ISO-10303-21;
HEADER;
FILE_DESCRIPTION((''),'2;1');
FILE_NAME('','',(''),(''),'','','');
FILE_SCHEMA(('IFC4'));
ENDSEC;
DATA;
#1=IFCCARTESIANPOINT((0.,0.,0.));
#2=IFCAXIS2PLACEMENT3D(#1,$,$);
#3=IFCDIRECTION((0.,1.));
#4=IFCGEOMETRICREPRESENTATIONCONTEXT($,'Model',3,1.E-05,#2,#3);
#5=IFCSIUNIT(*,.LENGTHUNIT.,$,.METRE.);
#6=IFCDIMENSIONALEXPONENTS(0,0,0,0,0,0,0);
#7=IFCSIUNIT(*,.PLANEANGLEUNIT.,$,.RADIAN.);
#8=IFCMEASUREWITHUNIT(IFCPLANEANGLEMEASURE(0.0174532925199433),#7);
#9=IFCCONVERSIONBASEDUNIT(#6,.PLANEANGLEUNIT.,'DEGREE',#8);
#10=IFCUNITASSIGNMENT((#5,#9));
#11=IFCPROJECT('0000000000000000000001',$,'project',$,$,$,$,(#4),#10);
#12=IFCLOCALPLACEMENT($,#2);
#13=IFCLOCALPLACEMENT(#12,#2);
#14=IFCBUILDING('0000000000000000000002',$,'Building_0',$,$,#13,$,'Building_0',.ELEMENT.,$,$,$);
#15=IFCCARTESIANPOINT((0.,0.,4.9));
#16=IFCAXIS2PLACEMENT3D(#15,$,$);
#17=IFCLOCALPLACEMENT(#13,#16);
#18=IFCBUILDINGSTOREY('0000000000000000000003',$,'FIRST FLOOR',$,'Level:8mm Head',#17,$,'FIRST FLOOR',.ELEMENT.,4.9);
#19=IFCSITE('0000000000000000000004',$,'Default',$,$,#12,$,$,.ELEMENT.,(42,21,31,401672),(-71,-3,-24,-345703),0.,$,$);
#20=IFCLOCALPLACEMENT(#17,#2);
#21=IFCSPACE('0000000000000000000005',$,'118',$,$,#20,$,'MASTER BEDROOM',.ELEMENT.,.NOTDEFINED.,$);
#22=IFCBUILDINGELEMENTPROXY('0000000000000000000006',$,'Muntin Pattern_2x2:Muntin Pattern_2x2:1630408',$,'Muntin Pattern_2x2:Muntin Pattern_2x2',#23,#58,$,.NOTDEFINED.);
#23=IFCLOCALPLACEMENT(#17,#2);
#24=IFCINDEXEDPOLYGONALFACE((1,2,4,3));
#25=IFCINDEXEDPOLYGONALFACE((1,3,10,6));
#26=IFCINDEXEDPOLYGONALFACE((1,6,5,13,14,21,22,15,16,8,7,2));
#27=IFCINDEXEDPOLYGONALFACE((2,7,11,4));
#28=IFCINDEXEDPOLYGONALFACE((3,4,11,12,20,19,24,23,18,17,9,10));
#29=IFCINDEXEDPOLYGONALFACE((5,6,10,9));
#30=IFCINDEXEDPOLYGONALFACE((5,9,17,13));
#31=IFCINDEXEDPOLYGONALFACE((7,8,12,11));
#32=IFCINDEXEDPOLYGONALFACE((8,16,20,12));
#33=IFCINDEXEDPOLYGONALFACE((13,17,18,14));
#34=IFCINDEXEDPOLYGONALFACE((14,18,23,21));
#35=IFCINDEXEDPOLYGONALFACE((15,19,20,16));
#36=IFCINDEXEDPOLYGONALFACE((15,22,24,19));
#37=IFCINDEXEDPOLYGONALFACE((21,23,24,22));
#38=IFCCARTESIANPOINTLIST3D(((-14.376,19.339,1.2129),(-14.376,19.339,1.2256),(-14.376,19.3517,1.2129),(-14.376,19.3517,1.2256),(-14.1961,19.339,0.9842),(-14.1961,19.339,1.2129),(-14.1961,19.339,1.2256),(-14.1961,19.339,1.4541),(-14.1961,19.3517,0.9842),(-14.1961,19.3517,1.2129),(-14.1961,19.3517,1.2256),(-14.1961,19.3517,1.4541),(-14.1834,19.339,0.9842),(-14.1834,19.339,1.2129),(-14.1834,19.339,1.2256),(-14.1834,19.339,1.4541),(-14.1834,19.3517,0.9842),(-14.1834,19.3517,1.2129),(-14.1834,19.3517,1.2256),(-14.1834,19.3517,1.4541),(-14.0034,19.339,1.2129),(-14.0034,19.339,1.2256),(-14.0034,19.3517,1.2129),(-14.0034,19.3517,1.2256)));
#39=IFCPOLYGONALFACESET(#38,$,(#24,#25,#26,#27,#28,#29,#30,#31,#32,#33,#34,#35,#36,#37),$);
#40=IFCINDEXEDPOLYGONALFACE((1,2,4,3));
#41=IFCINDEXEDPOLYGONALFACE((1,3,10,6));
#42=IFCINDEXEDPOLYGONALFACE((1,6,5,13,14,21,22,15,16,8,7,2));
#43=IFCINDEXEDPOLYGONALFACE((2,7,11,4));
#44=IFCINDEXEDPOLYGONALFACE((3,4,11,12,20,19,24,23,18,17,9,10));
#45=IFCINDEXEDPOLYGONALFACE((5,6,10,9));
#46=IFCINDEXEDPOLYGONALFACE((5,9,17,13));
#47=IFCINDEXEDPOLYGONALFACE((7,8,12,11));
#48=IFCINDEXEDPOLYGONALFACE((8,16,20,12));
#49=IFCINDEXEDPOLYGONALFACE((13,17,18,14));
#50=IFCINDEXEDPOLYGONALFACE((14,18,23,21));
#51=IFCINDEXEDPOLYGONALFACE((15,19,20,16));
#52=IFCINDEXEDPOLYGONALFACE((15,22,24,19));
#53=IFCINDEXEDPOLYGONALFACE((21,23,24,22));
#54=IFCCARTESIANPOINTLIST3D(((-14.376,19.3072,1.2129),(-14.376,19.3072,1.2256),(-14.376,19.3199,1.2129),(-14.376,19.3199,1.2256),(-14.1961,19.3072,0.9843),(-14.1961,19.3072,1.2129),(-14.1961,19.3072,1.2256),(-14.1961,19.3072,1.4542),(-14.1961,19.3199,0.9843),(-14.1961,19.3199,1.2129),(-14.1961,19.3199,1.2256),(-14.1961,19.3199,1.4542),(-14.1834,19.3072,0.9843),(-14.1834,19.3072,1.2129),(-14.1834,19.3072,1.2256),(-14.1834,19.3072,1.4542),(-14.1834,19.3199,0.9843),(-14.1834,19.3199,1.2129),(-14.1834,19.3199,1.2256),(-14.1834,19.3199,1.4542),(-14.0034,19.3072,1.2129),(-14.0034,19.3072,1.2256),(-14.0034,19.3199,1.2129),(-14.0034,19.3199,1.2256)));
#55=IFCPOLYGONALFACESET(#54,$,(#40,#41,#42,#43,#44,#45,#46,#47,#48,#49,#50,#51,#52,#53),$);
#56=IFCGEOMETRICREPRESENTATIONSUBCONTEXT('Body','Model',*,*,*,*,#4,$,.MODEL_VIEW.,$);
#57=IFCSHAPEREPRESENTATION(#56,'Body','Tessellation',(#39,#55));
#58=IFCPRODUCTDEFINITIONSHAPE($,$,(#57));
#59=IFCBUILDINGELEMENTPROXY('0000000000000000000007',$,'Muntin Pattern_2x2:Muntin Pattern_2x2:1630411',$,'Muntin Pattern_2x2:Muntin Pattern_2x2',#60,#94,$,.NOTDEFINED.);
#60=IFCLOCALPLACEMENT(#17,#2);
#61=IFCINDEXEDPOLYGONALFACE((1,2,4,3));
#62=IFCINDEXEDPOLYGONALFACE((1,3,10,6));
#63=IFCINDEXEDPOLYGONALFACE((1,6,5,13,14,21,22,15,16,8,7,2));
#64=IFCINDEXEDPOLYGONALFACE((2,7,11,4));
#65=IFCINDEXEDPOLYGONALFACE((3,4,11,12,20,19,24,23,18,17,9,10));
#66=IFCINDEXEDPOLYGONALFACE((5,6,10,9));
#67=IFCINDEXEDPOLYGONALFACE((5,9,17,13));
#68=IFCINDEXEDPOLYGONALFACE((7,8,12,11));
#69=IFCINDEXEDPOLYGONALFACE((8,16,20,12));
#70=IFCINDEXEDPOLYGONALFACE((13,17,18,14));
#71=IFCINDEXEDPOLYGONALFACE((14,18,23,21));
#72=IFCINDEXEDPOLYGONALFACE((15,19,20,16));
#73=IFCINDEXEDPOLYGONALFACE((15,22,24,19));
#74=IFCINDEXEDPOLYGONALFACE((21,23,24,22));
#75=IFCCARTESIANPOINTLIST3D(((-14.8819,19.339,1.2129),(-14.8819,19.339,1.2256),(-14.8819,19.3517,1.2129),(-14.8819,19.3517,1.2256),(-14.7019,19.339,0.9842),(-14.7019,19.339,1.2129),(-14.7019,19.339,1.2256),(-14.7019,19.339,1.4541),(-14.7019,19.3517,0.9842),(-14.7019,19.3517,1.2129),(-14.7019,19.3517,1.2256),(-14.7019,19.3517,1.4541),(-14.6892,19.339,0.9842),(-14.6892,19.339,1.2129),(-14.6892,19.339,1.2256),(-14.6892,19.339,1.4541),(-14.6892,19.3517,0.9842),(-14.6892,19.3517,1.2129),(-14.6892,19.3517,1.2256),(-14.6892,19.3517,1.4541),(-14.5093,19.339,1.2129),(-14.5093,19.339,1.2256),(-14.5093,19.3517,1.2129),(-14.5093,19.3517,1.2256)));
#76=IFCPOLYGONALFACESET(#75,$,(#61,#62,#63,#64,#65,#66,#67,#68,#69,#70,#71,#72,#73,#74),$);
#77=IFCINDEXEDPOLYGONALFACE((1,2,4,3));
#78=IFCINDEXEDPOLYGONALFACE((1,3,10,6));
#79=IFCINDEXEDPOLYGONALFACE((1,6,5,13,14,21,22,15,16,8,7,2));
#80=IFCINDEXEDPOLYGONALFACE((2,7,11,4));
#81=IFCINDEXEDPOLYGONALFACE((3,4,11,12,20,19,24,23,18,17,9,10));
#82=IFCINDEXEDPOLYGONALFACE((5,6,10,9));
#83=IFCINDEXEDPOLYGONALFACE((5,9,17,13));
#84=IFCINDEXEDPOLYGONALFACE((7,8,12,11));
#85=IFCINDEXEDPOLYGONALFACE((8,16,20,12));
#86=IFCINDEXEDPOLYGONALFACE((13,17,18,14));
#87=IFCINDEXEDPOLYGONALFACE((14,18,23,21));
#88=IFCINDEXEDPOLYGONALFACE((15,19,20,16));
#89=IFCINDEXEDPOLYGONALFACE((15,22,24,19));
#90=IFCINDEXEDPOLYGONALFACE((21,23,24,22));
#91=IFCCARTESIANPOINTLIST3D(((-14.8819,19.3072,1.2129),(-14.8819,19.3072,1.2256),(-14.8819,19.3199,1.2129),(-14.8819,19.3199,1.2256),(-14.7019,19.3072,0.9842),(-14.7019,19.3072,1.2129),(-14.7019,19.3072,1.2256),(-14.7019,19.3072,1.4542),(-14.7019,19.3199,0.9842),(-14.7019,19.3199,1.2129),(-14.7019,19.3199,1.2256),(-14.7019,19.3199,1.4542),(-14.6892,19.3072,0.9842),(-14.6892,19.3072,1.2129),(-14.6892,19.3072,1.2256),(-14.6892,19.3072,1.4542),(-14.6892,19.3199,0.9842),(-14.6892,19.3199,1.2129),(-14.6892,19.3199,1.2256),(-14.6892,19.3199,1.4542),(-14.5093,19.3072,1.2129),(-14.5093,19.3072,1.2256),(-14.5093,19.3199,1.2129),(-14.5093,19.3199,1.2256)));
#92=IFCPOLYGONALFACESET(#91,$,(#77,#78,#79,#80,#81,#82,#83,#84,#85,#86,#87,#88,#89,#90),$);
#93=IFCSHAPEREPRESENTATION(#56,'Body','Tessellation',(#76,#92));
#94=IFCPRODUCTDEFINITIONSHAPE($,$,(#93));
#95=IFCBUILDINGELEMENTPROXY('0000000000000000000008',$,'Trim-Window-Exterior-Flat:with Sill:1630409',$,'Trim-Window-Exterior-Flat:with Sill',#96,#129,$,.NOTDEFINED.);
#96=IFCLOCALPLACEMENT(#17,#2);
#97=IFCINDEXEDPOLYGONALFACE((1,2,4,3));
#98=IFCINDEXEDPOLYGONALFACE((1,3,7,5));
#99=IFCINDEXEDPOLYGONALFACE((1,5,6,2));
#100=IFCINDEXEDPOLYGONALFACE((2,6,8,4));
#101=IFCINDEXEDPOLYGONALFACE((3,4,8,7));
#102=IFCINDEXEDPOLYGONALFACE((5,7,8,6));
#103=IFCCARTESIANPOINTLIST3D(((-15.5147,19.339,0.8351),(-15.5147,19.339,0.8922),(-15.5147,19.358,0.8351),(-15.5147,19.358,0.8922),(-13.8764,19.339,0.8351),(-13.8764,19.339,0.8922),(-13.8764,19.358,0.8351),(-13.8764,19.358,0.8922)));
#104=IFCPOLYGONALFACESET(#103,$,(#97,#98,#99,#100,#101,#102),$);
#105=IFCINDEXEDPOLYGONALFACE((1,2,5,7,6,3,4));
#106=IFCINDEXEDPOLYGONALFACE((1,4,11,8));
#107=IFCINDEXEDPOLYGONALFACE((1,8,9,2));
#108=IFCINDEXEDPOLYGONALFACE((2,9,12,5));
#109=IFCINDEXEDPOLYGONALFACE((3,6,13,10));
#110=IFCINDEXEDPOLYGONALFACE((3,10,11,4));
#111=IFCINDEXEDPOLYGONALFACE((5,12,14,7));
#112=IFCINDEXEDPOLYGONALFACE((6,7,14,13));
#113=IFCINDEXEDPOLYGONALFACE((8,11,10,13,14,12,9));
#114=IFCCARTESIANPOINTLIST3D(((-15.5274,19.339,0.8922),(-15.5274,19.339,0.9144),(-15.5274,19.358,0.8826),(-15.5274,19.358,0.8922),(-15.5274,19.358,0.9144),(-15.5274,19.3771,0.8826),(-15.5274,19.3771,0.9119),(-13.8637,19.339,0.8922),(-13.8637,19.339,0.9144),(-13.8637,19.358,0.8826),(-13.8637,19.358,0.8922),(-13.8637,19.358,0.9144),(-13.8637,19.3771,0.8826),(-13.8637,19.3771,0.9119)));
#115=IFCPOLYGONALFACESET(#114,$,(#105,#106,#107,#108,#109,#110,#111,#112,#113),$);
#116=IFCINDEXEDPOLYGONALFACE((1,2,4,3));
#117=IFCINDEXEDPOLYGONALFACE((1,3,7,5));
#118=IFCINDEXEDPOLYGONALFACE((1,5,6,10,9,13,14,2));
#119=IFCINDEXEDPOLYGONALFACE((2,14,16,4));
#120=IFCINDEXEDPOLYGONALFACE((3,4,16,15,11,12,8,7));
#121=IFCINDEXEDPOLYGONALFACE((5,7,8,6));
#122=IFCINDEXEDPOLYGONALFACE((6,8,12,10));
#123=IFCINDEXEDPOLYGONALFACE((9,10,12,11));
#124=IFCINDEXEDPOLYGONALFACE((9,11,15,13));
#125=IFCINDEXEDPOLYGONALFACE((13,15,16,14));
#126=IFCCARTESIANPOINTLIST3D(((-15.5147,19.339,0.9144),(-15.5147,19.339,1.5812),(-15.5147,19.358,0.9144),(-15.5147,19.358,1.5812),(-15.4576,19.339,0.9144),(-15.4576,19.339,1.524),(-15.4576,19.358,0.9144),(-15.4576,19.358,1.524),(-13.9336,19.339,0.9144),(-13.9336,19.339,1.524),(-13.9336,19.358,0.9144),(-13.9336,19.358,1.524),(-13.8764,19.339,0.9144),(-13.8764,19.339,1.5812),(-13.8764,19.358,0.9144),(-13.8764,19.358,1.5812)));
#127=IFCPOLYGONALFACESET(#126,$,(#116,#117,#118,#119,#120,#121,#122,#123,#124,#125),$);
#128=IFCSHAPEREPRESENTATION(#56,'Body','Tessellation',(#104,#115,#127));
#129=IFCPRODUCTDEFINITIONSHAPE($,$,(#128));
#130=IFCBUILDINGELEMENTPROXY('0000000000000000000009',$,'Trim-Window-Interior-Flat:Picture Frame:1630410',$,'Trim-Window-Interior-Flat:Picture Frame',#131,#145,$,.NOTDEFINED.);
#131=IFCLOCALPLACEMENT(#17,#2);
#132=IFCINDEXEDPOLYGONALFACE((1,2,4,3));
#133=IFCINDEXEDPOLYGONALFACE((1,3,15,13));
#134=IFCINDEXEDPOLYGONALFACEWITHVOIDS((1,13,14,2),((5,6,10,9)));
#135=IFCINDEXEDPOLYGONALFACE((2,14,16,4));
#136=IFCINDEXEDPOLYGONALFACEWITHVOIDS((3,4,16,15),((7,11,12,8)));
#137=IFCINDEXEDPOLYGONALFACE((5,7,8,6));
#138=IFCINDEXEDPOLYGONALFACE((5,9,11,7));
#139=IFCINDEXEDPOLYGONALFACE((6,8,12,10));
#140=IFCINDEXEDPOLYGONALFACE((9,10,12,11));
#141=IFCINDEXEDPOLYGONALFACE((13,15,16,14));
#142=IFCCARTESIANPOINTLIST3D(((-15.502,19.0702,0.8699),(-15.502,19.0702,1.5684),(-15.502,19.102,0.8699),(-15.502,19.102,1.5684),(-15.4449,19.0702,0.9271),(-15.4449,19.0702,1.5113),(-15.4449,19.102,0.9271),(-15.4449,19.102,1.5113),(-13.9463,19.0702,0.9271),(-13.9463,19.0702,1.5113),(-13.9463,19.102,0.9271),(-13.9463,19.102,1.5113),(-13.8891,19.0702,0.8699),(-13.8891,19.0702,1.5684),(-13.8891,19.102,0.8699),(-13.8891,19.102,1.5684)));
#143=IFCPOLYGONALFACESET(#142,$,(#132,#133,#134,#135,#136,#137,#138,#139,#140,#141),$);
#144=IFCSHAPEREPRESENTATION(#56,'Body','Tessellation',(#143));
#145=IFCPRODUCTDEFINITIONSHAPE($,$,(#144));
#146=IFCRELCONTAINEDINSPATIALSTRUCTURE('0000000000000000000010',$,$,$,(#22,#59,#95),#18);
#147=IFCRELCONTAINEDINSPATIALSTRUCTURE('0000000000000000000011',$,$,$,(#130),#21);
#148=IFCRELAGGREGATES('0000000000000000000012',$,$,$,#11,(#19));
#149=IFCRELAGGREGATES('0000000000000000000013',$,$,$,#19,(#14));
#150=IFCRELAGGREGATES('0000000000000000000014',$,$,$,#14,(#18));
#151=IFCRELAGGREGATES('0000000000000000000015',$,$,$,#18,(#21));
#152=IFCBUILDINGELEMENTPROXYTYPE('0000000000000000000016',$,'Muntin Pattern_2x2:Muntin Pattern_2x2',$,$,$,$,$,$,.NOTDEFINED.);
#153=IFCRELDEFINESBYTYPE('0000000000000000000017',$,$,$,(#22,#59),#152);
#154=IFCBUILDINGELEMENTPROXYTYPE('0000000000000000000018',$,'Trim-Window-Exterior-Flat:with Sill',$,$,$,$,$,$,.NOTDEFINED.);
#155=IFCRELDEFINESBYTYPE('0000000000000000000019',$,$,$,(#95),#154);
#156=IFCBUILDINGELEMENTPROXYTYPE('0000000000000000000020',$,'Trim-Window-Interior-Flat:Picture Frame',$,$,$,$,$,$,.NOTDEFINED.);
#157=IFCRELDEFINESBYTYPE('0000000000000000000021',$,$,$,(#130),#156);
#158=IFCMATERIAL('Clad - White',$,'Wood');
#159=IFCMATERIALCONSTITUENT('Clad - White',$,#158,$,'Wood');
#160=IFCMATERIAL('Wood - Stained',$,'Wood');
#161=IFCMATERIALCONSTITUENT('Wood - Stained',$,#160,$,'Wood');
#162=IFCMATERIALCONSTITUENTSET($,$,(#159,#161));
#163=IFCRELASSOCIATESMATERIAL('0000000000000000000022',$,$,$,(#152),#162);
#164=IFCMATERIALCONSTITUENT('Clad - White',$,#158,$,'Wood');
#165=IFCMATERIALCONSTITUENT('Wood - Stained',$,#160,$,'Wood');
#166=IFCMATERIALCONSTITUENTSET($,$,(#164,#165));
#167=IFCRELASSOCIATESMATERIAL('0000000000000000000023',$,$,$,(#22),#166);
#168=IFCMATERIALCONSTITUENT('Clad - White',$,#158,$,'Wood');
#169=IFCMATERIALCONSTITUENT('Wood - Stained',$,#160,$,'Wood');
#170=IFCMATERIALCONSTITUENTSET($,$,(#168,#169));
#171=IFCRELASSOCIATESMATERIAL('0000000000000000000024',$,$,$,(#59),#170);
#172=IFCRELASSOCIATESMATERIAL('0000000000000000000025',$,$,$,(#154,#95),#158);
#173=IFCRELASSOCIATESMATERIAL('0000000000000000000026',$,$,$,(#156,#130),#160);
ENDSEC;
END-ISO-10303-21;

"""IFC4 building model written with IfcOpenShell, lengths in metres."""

from ifc_helpers import new_model, entity, si_unit, converted_unit, direction, frame, origin, place, context, subcontext, project, spatial, indexed_curve, outline, extrude, source, transform, mapped, material, constituent, constituent_set, type_object, type_shapes, element, save


model = new_model("IFC4")

# Units and contexts
model_context = context("Model", 3, precision=1e-05, world=origin(), true_north=direction((0.0, 1.0)))
body_context = subcontext(model_context, "Body", "Model", "MODEL_VIEW")
ifc_project = project(units=[si_unit("LENGTHUNIT", "METRE"), converted_unit("PLANEANGLEUNIT", "DEGREE", entity("IfcPlaneAngleMeasure", 0.0174532925199433), si_unit("PLANEANGLEUNIT", "RADIAN"), dimensions=[0, 0, 0, 0, 0, 0, 0])], contexts=[model_context])

# Site, building, storey
site_placement = place(None, origin())
site = spatial("IfcSite", under=ifc_project, at=site_placement, Name="Default", CompositionType="ELEMENT", RefLatitude=(42, 21, 31, 401672), RefLongitude=(-71, -3, -24, -345703), RefElevation=0.0)
building_placement = place(site_placement, origin())
building = spatial("IfcBuilding", under=site, at=building_placement, Name="Building_0", LongName="Building_0", CompositionType="ELEMENT")
storey_placement = place(building_placement, frame((0.0, 0.0, 4.9)))
storey = spatial("IfcBuildingStorey", under=building, at=storey_placement, Name="FIRST FLOOR", ObjectType="Level:8mm Head", LongName="FIRST FLOOR", CompositionType="ELEMENT", Elevation=4.9)

# Shared definitions
ifc_material_1 = material(Name="Clad - White", Category="Wood")

# Building element proxies
ifc_constituent_1 = constituent(ifc_material_1, Name="Clad - White", Category="Wood")
ifc_material_2 = material(Name="Wood - Stained", Category="Wood")
ifc_constituent_2 = constituent(ifc_material_2, Name="Wood - Stained", Category="Wood")
ifc_constituent_set_1 = constituent_set(constituents=[ifc_constituent_1, ifc_constituent_2])
ifc_constituent_3 = constituent(ifc_material_1, Name="Clad - White", Category="Wood")
ifc_constituent_4 = constituent(ifc_material_2, Name="Wood - Stained", Category="Wood")
ifc_constituent_set_2 = constituent_set(constituents=[ifc_constituent_3, ifc_constituent_4])
building_element_proxy_type_1 = type_object("IfcBuildingElementProxyType", Name="Muntin Pattern_2x2:Muntin Pattern_2x2", PredefinedType="NOTDEFINED", material=ifc_constituent_set_2)
shared_shape_1 = source(origin(), body_context, "Body", "SweptSolid", [
    extrude(outline(indexed_curve([(0.0064, -0.0064), (0.2349, -0.0064), (0.2349, 0.0063), (0.0064, 0.0063), (0.0064, 0.1863), (-0.0063, 0.1863), (-0.0063, 0.0063), (-0.235, 0.0063), (-0.235, -0.0064), (-0.0063, -0.0064), (-0.0063, -0.1863), (0.0064, -0.1863), (0.0064, -0.0064)], self_intersect=False)), frame((0.0, -0.0222, 0.2349), z_axis=(0.0, 1.0, 0.0), x_axis=(0.0, 0.0, 1.0)), (0.0, 0.0, 1.0), 0.0127),
    extrude(outline(indexed_curve([(0.0064, -0.0064), (0.235, -0.0064), (0.235, 0.0063), (0.0064, 0.0063), (0.0064, 0.1863), (-0.0063, 0.1863), (-0.0063, 0.0063), (-0.235, 0.0063), (-0.235, -0.0064), (-0.0063, -0.0064), (-0.0063, -0.1863), (0.0064, -0.1863), (0.0064, -0.0064)], self_intersect=False)), frame((0.0, 0.0095, 0.235), z_axis=(0.0, 1.0, 0.0), x_axis=(0.0, 0.0, 1.0)), (0.0, 0.0, 1.0), 0.0127),
])
type_shapes(building_element_proxy_type_1, [shared_shape_1])
proxy_1_placement = place(storey_placement, frame((-14.1897, 19.3295, 0.9843), z_axis=(0.0, 0.0, 1.0), x_axis=(-1.0, 0.0, 0.0)))
element("IfcBuildingElementProxy", 1, at=proxy_1_placement, inside=storey, type_object=building_element_proxy_type_1, material=ifc_constituent_set_1, Name="Muntin Pattern_2x2:Muntin Pattern_2x2:1630408", ObjectType="Muntin Pattern_2x2:Muntin Pattern_2x2", PredefinedType="NOTDEFINED", context=body_context, shape_type="MappedRepresentation", body=[
    mapped(shared_shape_1, transform((0.0, 0.0, 0.0), scale=1.0)),
])
ifc_constituent_5 = constituent(ifc_material_1, Name="Clad - White", Category="Wood")
ifc_constituent_6 = constituent(ifc_material_2, Name="Wood - Stained", Category="Wood")
ifc_constituent_set_3 = constituent_set(constituents=[ifc_constituent_5, ifc_constituent_6])
proxy_2_placement = place(storey_placement, frame((-14.6956, 19.3295, 0.9842), z_axis=(0.0, 0.0, 1.0), x_axis=(-1.0, 0.0, 0.0)))
element("IfcBuildingElementProxy", 2, at=proxy_2_placement, inside=storey, type_object=building_element_proxy_type_1, material=ifc_constituent_set_3, Name="Muntin Pattern_2x2:Muntin Pattern_2x2:1630411", ObjectType="Muntin Pattern_2x2:Muntin Pattern_2x2", PredefinedType="NOTDEFINED", context=body_context, shape_type="MappedRepresentation", body=[
    mapped(shared_shape_1, transform((0.0, 0.0, 0.0), scale=1.0)),
])
building_element_proxy_type_2 = type_object("IfcBuildingElementProxyType", Name="Trim-Window-Exterior-Flat:with Sill", PredefinedType="NOTDEFINED", material=ifc_material_1)
shared_shape_2 = source(origin(), body_context, "Body", "SweptSolid", [
    extrude(outline(indexed_curve([(-0.8191, -0.0286), (0.8191, -0.0286), (0.8191, 0.0286), (-0.8191, 0.0286), (-0.8191, -0.0286)], self_intersect=False)), frame((0.0, -0.6604, 0.0), z_axis=(0.0, 0.0, 1.0), x_axis=(-1.0, 0.0, 0.0)), (0.0, 0.0, 1.0), 0.0191),
    extrude(outline(indexed_curve([(-0.019, -0.016), (0.0, -0.016), (0.0, -0.0064), (0.019, -0.0064), (0.019, 0.0158), (0.0, 0.0158), (-0.019, 0.0133), (-0.019, -0.016)], self_intersect=False)), frame((-0.8318, -0.6254, 0.019), z_axis=(1.0, 0.0, 0.0), x_axis=(0.0, 0.0, -1.0)), (0.0, 0.0, 1.0), 1.6637),
    extrude(outline(indexed_curve([(-0.3477, -0.8192), (0.3191, -0.8192), (0.3191, -0.762), (-0.2905, -0.762), (-0.2905, 0.762), (0.3191, 0.762), (0.3191, 0.8191), (-0.3477, 0.8191), (-0.3477, -0.8192)], self_intersect=False)), frame((0.0, -0.2905, 0.0), z_axis=(0.0, 0.0, 1.0), x_axis=(0.0, -1.0, 0.0)), (0.0, 0.0, 1.0), 0.0191),
])
type_shapes(building_element_proxy_type_2, [shared_shape_2])
proxy_3_placement = place(storey_placement, frame((-14.6956, 19.339, 1.524), z_axis=(0.0, 1.0, 0.0), x_axis=(-1.0, 0.0, 0.0)))
element("IfcBuildingElementProxy", 3, at=proxy_3_placement, inside=storey, type_object=building_element_proxy_type_2, material=ifc_material_1, Name="Trim-Window-Exterior-Flat:with Sill:1630409", ObjectType="Trim-Window-Exterior-Flat:with Sill", PredefinedType="NOTDEFINED", context=body_context, shape_type="MappedRepresentation", body=[
    mapped(shared_shape_2, transform((0.0, 0.0, 0.0), scale=1.0)),
])

# Shared definitions
space_1_placement = place(storey_placement, origin())
space_1 = spatial("IfcSpace", under=storey, at=space_1_placement, Name="118", LongName="MASTER BEDROOM", CompositionType="ELEMENT", PredefinedType="NOTDEFINED")

# Building element proxy
building_element_proxy_type_3 = type_object("IfcBuildingElementProxyType", Name="Trim-Window-Interior-Flat:Picture Frame", PredefinedType="NOTDEFINED", material=ifc_material_2)
shared_shape_3 = source(origin(), body_context, "Body", "SweptSolid", [
    extrude(outline(indexed_curve([(-0.8064, -0.3492), (0.8064, -0.3492), (0.8064, 0.3492), (-0.8064, 0.3492), (-0.8064, -0.3492)], self_intersect=False), holes=[indexed_curve([(-0.7493, -0.2921), (-0.7493, 0.2921), (0.7493, 0.2921), (0.7493, -0.2921), (-0.7493, -0.2921)], self_intersect=False)]), frame((0.0, -0.3048, 0.0), z_axis=(0.0, 0.0, 1.0), x_axis=(-1.0, 0.0, 0.0)), (0.0, 0.0, 1.0), 0.0318),
])
type_shapes(building_element_proxy_type_3, [shared_shape_3])
proxy_4_placement = place(space_1_placement, frame((-14.6956, 19.102, 1.524), z_axis=(0.0, -1.0, 0.0), x_axis=(1.0, 0.0, 0.0)))
element("IfcBuildingElementProxy", 4, at=proxy_4_placement, inside=space_1, type_object=building_element_proxy_type_3, material=ifc_material_2, Name="Trim-Window-Interior-Flat:Picture Frame:1630410", ObjectType="Trim-Window-Interior-Flat:Picture Frame", PredefinedType="NOTDEFINED", context=body_context, shape_type="MappedRepresentation", body=[
    mapped(shared_shape_3, transform((0.0, 0.0, 0.0), scale=1.0)),
])

save(model, "model.ifc")
